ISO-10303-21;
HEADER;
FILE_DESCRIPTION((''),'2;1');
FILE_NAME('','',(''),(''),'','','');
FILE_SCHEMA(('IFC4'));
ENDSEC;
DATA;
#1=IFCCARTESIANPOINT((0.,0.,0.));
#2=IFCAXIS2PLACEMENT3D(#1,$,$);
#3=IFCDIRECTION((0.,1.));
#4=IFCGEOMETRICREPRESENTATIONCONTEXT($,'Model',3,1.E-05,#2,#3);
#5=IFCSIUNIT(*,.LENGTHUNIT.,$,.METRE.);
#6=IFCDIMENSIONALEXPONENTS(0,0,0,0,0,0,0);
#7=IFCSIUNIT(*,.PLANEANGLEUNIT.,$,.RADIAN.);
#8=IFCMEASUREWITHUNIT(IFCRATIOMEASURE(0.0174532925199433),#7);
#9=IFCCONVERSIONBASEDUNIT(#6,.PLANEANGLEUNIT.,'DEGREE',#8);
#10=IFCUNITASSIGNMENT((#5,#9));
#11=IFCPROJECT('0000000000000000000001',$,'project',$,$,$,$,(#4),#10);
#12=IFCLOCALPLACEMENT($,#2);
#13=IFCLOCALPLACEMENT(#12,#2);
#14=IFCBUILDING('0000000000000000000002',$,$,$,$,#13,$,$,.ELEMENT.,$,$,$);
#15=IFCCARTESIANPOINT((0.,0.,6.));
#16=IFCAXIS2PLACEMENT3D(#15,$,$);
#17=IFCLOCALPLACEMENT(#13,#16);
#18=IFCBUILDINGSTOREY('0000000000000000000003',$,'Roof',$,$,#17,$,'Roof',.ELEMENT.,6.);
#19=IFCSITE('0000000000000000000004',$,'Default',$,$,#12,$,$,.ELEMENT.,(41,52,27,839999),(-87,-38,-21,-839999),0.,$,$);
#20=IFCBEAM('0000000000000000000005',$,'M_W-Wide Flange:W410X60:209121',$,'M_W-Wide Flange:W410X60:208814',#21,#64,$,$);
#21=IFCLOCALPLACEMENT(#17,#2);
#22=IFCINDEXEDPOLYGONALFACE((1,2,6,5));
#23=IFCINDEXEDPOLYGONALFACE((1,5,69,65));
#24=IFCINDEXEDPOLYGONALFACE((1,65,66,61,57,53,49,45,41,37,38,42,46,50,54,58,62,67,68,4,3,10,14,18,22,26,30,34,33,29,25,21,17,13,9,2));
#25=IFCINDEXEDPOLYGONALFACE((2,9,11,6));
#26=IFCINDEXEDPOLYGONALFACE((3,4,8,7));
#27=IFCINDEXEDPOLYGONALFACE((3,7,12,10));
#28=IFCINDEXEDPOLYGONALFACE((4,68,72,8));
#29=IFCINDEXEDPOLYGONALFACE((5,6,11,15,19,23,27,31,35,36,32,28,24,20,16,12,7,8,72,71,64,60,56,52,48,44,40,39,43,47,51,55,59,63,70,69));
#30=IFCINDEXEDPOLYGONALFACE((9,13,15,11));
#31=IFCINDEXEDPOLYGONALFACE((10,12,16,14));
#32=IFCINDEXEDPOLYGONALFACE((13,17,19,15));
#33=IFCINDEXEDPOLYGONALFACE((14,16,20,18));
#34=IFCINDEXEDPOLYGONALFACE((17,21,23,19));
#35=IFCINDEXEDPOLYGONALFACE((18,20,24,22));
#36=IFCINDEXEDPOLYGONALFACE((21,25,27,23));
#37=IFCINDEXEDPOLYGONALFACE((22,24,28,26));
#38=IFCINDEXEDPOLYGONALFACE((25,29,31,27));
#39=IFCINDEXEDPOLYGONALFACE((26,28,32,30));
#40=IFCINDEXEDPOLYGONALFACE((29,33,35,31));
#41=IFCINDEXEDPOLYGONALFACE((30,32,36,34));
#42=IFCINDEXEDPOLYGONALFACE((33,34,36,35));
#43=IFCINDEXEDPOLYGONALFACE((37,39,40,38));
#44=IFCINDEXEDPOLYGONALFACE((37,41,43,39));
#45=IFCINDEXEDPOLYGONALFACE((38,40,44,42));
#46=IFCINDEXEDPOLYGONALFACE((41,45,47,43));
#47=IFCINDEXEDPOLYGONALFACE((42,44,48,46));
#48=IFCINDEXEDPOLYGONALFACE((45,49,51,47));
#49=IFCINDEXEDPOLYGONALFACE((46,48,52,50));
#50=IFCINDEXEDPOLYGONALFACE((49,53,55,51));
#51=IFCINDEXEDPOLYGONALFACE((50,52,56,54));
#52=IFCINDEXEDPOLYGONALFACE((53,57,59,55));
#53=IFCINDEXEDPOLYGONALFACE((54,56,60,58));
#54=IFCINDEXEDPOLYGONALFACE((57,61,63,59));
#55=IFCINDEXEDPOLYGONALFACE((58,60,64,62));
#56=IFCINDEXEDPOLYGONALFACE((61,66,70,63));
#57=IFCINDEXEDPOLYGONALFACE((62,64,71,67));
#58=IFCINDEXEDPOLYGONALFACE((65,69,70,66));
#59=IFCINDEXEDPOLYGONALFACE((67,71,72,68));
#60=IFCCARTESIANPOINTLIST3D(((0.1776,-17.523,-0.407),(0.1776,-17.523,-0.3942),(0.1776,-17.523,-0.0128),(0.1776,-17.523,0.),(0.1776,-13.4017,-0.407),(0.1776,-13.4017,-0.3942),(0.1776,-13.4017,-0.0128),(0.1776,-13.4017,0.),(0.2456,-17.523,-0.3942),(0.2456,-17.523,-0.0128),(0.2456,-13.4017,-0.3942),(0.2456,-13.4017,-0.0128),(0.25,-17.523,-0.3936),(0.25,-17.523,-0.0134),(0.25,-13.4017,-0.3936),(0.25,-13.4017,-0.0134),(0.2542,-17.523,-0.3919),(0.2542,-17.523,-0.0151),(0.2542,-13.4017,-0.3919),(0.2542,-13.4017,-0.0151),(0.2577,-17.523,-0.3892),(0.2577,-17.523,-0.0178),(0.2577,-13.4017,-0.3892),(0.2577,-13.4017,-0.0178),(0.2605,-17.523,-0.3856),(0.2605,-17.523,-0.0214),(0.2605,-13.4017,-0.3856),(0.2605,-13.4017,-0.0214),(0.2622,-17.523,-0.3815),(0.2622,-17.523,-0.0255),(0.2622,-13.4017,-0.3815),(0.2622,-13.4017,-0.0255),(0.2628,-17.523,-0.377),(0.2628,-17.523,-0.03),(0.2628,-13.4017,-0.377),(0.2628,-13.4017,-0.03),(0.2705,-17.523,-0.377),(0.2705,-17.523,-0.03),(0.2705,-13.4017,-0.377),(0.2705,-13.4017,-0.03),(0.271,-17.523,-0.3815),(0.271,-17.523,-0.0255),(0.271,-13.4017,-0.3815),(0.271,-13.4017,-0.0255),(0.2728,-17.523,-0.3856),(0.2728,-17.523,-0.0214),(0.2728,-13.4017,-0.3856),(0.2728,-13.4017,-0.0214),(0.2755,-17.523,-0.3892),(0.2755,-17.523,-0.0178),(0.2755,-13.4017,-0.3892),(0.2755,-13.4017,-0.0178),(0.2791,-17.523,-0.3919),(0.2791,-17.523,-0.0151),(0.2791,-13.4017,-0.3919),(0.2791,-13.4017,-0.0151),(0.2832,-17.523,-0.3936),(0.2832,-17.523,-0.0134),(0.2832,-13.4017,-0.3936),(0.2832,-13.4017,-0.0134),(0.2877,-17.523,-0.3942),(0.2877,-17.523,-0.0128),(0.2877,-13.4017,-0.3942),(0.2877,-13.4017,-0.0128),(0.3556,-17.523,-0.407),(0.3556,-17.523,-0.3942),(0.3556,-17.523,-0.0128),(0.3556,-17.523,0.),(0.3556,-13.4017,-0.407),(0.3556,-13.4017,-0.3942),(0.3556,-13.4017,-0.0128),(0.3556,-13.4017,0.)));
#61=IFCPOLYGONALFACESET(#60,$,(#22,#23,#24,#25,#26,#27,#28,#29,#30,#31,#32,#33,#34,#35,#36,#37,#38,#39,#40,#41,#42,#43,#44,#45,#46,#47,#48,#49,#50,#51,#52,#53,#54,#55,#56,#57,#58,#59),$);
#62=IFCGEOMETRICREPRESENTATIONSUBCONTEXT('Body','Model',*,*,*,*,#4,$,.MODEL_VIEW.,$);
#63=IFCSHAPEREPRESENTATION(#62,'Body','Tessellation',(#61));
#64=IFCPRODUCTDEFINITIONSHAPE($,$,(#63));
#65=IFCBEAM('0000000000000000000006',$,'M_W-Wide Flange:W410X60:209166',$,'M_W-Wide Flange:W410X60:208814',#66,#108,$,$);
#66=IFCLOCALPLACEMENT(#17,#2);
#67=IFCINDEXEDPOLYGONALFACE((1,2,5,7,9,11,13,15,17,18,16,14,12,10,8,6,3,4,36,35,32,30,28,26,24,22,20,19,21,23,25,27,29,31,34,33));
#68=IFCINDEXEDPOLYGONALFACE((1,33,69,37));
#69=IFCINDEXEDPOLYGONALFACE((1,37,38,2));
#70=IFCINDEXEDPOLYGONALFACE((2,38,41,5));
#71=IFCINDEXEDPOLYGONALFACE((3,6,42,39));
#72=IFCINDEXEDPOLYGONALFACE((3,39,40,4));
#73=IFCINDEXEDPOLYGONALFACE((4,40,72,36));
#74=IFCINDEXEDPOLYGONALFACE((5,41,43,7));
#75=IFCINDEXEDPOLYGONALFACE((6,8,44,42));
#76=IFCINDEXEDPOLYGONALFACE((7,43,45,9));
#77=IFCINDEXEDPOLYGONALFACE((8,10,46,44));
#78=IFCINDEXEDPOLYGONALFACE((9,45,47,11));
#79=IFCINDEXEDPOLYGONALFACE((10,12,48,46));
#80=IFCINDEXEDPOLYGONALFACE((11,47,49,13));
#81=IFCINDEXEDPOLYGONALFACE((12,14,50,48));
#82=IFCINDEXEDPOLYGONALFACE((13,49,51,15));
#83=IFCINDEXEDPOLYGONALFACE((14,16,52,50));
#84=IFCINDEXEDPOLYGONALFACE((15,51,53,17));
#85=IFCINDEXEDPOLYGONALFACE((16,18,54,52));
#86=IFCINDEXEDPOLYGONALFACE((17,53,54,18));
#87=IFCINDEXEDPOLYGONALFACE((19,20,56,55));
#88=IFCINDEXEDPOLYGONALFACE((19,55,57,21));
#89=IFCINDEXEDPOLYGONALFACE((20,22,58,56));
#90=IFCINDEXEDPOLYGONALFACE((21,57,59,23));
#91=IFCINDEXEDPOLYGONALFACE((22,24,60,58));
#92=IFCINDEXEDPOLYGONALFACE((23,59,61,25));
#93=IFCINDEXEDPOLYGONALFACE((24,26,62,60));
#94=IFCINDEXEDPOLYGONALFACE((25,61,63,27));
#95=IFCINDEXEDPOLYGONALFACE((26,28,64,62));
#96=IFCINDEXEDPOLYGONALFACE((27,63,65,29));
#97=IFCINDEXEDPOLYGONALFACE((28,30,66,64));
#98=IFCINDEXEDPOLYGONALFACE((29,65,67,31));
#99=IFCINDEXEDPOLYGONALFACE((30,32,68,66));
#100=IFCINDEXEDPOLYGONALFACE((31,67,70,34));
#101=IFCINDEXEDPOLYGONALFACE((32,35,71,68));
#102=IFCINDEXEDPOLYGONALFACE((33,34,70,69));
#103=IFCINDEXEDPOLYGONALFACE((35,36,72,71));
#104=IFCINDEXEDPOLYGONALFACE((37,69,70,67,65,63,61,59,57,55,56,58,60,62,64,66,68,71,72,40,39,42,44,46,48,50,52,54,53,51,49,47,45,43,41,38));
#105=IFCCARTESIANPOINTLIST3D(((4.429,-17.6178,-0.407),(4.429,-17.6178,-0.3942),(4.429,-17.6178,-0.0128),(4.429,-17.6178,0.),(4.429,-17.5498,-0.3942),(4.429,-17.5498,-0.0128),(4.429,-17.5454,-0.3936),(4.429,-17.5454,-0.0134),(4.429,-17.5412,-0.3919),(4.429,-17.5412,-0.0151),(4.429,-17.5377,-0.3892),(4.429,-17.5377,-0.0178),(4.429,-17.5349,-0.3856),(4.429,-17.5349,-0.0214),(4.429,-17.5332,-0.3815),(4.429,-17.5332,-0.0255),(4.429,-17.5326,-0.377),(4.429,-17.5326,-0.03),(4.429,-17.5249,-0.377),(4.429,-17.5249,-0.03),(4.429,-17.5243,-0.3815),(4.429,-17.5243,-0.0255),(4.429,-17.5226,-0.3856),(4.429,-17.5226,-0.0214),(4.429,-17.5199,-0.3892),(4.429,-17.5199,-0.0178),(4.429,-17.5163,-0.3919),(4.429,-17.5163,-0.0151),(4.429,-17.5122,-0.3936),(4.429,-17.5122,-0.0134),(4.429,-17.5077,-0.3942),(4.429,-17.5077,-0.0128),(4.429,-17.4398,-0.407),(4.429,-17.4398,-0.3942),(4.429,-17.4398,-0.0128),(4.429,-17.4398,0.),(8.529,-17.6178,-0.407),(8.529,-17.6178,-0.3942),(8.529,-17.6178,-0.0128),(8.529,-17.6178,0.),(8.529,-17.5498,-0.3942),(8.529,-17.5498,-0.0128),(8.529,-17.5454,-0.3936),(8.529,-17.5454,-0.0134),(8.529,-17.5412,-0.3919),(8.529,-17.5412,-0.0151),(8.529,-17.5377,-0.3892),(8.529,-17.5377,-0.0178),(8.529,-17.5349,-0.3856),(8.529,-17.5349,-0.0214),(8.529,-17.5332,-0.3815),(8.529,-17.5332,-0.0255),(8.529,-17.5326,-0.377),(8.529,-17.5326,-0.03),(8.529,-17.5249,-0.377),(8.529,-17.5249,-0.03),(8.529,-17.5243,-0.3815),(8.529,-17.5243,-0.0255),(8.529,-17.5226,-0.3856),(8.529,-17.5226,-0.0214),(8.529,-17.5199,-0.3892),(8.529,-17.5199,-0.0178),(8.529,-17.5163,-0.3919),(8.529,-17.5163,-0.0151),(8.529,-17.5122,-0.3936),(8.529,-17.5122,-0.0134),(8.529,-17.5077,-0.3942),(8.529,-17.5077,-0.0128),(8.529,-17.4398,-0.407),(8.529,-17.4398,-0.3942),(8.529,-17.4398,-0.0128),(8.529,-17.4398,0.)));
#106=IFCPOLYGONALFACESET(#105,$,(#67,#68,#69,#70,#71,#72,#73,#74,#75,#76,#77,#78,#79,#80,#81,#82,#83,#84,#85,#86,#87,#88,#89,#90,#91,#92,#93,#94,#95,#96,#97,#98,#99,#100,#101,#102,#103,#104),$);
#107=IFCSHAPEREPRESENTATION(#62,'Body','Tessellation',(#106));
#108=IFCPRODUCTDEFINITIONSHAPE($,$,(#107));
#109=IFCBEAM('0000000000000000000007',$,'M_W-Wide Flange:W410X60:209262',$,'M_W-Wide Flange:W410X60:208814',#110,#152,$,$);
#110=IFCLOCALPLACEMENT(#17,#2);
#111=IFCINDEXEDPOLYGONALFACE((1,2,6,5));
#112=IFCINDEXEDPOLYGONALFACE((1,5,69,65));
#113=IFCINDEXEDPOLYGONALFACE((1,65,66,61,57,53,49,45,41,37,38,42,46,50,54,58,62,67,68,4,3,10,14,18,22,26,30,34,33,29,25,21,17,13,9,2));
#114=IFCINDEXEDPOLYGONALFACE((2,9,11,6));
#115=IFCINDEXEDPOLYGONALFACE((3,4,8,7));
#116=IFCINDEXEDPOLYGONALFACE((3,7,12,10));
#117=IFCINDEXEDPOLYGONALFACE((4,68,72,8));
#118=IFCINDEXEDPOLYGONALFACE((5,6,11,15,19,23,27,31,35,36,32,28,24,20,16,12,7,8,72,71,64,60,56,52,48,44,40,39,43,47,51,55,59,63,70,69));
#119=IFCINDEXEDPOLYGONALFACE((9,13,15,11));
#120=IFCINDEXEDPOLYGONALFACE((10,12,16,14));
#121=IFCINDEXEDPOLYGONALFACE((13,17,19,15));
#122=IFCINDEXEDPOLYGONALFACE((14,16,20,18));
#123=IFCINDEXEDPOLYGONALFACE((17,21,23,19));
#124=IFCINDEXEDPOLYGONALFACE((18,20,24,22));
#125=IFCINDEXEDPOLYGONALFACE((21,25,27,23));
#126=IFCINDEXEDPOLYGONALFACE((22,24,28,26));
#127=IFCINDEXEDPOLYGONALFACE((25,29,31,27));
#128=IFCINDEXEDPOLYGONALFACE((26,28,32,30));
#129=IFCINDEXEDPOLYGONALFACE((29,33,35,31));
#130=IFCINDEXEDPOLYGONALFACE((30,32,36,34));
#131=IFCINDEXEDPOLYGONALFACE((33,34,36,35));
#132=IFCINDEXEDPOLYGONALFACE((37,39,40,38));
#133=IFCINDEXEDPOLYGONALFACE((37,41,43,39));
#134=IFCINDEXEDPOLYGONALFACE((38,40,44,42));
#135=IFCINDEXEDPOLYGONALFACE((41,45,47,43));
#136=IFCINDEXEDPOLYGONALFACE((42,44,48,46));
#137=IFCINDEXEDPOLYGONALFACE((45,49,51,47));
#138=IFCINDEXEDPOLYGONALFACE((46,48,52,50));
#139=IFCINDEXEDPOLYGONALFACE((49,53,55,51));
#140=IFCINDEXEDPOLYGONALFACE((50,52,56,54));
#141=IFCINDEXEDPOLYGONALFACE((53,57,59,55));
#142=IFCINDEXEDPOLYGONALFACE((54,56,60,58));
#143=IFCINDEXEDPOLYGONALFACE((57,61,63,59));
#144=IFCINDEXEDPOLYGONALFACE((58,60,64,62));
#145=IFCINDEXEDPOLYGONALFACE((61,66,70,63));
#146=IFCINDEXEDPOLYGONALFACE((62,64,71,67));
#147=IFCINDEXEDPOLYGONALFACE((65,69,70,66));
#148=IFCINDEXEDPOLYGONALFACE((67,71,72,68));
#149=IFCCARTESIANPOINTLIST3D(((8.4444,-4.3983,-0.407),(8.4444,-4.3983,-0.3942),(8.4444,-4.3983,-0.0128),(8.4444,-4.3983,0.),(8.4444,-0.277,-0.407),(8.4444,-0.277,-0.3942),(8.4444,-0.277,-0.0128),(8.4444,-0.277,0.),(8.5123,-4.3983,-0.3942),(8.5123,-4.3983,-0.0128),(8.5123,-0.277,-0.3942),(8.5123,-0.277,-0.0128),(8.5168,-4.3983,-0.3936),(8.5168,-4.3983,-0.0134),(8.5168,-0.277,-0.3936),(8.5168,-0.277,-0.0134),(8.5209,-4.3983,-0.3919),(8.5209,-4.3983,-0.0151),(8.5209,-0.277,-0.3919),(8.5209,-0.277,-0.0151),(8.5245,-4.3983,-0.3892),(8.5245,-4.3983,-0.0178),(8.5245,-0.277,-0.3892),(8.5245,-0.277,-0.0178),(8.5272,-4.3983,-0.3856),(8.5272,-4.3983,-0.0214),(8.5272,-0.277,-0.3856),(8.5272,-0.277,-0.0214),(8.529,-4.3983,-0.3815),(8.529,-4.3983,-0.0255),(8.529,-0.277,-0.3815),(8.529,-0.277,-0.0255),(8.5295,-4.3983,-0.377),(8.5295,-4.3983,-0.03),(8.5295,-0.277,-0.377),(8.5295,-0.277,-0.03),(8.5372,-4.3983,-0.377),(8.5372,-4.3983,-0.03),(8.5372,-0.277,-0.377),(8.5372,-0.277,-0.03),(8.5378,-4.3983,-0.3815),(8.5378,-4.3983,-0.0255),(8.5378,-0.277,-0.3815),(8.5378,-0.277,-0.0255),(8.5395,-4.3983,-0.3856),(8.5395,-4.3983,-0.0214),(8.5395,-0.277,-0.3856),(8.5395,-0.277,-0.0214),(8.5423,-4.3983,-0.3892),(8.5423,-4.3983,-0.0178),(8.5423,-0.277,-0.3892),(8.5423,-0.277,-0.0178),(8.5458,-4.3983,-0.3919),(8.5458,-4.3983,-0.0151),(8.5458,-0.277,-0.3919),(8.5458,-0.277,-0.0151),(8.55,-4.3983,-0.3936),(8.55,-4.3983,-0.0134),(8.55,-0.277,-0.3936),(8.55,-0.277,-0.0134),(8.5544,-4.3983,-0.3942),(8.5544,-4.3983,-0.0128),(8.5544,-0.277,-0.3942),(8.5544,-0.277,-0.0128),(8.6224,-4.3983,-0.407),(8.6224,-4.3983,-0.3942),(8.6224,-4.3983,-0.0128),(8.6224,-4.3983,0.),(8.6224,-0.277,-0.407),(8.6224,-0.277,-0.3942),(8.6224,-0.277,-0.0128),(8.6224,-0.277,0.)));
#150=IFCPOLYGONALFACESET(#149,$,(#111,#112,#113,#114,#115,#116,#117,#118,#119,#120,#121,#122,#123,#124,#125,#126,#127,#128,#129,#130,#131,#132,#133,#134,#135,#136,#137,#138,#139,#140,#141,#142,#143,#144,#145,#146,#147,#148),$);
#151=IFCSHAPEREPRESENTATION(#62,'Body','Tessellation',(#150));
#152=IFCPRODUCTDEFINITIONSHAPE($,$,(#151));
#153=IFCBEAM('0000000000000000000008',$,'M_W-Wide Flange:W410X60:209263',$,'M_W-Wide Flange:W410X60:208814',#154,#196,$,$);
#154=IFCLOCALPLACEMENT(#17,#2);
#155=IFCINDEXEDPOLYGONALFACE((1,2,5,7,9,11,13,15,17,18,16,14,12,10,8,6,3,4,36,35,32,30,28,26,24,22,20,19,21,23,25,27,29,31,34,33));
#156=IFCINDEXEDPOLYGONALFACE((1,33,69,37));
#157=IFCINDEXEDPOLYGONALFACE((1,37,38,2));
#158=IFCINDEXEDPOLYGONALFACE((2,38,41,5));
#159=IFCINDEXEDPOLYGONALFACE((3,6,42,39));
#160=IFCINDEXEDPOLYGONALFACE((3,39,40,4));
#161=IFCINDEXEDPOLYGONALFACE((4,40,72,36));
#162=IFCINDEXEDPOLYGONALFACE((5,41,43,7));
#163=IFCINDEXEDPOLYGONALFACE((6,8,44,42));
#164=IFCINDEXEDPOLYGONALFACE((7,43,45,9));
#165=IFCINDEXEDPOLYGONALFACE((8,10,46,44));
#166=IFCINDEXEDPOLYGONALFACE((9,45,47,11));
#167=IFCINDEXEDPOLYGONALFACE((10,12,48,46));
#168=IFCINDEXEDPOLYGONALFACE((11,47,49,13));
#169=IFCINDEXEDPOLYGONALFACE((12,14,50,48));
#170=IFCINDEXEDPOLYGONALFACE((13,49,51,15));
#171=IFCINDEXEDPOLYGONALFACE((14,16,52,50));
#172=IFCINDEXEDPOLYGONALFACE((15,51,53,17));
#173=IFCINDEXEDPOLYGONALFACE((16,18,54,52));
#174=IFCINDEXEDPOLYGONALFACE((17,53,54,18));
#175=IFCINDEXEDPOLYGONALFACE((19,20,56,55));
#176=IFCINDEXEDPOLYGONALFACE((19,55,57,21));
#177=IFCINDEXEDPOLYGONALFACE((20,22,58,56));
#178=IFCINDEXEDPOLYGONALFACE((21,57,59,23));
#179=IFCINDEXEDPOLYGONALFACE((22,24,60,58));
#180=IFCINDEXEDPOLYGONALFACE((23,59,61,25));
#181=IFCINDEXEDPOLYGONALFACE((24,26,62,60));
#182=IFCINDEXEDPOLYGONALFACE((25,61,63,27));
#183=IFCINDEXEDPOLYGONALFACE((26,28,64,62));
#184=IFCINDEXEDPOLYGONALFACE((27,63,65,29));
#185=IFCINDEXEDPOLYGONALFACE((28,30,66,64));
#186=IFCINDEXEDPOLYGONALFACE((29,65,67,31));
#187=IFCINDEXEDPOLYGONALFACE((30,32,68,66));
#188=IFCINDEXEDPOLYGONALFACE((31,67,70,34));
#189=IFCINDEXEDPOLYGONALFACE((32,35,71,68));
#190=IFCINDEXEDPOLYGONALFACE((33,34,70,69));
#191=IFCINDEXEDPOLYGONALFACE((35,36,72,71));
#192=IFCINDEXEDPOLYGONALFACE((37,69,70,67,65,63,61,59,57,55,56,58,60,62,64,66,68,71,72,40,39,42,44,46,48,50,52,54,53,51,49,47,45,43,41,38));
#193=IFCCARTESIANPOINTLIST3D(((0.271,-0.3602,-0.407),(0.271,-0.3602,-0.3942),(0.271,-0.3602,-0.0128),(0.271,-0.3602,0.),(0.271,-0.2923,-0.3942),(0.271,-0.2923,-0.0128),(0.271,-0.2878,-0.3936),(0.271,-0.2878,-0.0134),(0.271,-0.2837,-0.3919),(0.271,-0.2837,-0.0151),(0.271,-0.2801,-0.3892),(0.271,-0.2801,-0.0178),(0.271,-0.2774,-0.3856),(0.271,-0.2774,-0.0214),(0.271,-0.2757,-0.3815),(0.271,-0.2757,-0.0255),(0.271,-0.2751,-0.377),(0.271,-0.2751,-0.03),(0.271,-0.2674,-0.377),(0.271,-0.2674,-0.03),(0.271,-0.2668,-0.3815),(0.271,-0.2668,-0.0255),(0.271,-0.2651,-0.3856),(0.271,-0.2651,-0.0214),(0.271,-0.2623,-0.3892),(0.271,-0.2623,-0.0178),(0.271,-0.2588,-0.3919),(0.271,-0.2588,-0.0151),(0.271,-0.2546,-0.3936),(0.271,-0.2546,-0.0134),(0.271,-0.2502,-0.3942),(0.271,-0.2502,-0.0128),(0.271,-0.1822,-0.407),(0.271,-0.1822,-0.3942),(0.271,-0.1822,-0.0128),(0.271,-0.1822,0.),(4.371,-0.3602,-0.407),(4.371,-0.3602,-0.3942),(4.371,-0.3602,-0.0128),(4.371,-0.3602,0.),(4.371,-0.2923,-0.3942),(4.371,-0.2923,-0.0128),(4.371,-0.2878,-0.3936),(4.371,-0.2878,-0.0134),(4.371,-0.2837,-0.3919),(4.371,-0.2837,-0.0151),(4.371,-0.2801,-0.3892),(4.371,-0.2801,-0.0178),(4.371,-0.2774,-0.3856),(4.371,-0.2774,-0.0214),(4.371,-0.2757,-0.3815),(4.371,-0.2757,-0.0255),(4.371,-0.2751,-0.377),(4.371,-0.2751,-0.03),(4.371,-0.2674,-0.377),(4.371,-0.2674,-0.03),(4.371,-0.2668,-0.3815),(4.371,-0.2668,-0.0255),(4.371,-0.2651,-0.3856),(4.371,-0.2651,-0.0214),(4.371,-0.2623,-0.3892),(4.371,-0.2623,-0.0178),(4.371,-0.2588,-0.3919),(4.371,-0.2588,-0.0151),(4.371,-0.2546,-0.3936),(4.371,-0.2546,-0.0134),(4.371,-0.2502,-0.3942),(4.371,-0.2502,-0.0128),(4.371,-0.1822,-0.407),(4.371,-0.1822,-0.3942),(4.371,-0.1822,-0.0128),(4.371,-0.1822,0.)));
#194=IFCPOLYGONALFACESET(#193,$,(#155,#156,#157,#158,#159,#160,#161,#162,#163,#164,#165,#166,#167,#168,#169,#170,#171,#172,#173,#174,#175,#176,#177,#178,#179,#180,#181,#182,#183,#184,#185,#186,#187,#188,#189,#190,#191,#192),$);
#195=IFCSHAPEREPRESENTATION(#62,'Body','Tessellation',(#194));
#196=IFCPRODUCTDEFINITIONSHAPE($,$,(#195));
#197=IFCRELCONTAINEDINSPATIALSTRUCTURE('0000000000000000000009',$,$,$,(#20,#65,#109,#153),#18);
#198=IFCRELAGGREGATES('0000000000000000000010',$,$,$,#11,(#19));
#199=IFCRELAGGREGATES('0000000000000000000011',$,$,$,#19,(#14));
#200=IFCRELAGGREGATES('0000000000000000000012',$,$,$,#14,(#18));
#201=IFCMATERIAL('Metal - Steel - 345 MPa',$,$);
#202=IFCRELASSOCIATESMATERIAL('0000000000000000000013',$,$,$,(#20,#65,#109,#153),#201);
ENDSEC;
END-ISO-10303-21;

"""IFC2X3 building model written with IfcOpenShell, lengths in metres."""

from ifc_helpers import new_model, entity, si_unit, converted_unit, direction, frame, frame_2d, origin, place, context, subcontext, project, spatial, i_section, extrude, material, element, save


model = new_model("IFC2X3")

# Units and contexts
model_context = context("Model", 3, precision=1e-05, world=origin(), true_north=direction((0.0, 1.0)))
body_context = subcontext(model_context, "Body", "Model", "MODEL_VIEW")
ifc_project = project(units=[si_unit("LENGTHUNIT", "METRE"), converted_unit("PLANEANGLEUNIT", "DEGREE", entity("IfcRatioMeasure", 0.0174532925199433), si_unit("PLANEANGLEUNIT", "RADIAN"), dimensions=[0, 0, 0, 0, 0, 0, 0])], contexts=[model_context])

# Site, building, storey
site_placement = place(None, origin())
site = spatial("IfcSite", under=ifc_project, at=site_placement, Name="Default", CompositionType="ELEMENT", RefLatitude=(41, 52, 27, 839999), RefLongitude=(-87, -38, -21, -839999), RefElevation=0.0)
building_placement = place(site_placement, origin())
building = spatial("IfcBuilding", under=site, at=building_placement, CompositionType="ELEMENT")
storey_placement = place(building_placement, frame((0.0, 0.0, 6.0)))
storey = spatial("IfcBuildingStorey", under=building, at=storey_placement, Name="Roof", LongName="Roof", CompositionType="ELEMENT", Elevation=6.0)

# Beams
ifc_material_1 = material(Name="Metal - Steel - 345 MPa")
beam_1_placement = place(storey_placement, frame((0.2666, -13.4017, 0.0), z_axis=(0.0, 0.0, 1.0), x_axis=(0.0, -1.0, 0.0)))
element("IfcBeam", 1, at=beam_1_placement, inside=storey, material=ifc_material_1, Name="M_W-Wide Flange:W410X60:209121", ObjectType="M_W-Wide Flange:W410X60:208814", context=body_context, shape_type="SweptSolid", body=[
    extrude(i_section(OverallWidth=0.178, OverallDepth=0.407, WebThickness=0.0077, FlangeThickness=0.0128, FilletRadius=0.0172, at=frame_2d((0.0, 0.0), x_axis=(0.0, 1.0))), frame((0.0, 0.0, -0.2035), z_axis=(1.0, 0.0, 0.0), x_axis=(0.0, 0.0, -1.0)), (0.0, 0.0, 1.0), 4.1213),
])
beam_2_placement = place(storey_placement, frame((4.429, -17.5288, 0.0)))
element("IfcBeam", 2, at=beam_2_placement, inside=storey, material=ifc_material_1, Name="M_W-Wide Flange:W410X60:209166", ObjectType="M_W-Wide Flange:W410X60:208814", context=body_context, shape_type="SweptSolid", body=[
    extrude(i_section(OverallWidth=0.178, OverallDepth=0.407, WebThickness=0.0077, FlangeThickness=0.0128, FilletRadius=0.0172, at=frame_2d((0.0, 0.0), x_axis=(0.0, 1.0))), frame((0.0, 0.0, -0.2035), z_axis=(1.0, 0.0, 0.0), x_axis=(0.0, 0.0, -1.0)), (0.0, 0.0, 1.0), 4.1),
])
beam_3_placement = place(storey_placement, frame((8.5334, -4.3983, 0.0), z_axis=(0.0, 0.0, 1.0), x_axis=(0.0, 1.0, 0.0)))
element("IfcBeam", 3, at=beam_3_placement, inside=storey, material=ifc_material_1, Name="M_W-Wide Flange:W410X60:209262", ObjectType="M_W-Wide Flange:W410X60:208814", context=body_context, shape_type="SweptSolid", body=[
    extrude(i_section(OverallWidth=0.178, OverallDepth=0.407, WebThickness=0.0077, FlangeThickness=0.0128, FilletRadius=0.0172, at=frame_2d((0.0, 0.0), x_axis=(0.0, 1.0))), frame((0.0, 0.0, -0.2035), z_axis=(1.0, 0.0, 0.0), x_axis=(0.0, 0.0, -1.0)), (0.0, 0.0, 1.0), 4.1213),
])
beam_4_placement = place(storey_placement, frame((4.371, -0.2712, 0.0), z_axis=(0.0, 0.0, 1.0), x_axis=(-1.0, 0.0, 0.0)))
element("IfcBeam", 4, at=beam_4_placement, inside=storey, material=ifc_material_1, Name="M_W-Wide Flange:W410X60:209263", ObjectType="M_W-Wide Flange:W410X60:208814", context=body_context, shape_type="SweptSolid", body=[
    extrude(i_section(OverallWidth=0.178, OverallDepth=0.407, WebThickness=0.0077, FlangeThickness=0.0128, FilletRadius=0.0172, at=frame_2d((0.0, 0.0), x_axis=(0.0, 1.0))), frame((0.0, 0.0, -0.2035), z_axis=(1.0, 0.0, 0.0), x_axis=(0.0, 0.0, -1.0)), (0.0, 0.0, 1.0), 4.1),
])

save(model, "model.ifc")
